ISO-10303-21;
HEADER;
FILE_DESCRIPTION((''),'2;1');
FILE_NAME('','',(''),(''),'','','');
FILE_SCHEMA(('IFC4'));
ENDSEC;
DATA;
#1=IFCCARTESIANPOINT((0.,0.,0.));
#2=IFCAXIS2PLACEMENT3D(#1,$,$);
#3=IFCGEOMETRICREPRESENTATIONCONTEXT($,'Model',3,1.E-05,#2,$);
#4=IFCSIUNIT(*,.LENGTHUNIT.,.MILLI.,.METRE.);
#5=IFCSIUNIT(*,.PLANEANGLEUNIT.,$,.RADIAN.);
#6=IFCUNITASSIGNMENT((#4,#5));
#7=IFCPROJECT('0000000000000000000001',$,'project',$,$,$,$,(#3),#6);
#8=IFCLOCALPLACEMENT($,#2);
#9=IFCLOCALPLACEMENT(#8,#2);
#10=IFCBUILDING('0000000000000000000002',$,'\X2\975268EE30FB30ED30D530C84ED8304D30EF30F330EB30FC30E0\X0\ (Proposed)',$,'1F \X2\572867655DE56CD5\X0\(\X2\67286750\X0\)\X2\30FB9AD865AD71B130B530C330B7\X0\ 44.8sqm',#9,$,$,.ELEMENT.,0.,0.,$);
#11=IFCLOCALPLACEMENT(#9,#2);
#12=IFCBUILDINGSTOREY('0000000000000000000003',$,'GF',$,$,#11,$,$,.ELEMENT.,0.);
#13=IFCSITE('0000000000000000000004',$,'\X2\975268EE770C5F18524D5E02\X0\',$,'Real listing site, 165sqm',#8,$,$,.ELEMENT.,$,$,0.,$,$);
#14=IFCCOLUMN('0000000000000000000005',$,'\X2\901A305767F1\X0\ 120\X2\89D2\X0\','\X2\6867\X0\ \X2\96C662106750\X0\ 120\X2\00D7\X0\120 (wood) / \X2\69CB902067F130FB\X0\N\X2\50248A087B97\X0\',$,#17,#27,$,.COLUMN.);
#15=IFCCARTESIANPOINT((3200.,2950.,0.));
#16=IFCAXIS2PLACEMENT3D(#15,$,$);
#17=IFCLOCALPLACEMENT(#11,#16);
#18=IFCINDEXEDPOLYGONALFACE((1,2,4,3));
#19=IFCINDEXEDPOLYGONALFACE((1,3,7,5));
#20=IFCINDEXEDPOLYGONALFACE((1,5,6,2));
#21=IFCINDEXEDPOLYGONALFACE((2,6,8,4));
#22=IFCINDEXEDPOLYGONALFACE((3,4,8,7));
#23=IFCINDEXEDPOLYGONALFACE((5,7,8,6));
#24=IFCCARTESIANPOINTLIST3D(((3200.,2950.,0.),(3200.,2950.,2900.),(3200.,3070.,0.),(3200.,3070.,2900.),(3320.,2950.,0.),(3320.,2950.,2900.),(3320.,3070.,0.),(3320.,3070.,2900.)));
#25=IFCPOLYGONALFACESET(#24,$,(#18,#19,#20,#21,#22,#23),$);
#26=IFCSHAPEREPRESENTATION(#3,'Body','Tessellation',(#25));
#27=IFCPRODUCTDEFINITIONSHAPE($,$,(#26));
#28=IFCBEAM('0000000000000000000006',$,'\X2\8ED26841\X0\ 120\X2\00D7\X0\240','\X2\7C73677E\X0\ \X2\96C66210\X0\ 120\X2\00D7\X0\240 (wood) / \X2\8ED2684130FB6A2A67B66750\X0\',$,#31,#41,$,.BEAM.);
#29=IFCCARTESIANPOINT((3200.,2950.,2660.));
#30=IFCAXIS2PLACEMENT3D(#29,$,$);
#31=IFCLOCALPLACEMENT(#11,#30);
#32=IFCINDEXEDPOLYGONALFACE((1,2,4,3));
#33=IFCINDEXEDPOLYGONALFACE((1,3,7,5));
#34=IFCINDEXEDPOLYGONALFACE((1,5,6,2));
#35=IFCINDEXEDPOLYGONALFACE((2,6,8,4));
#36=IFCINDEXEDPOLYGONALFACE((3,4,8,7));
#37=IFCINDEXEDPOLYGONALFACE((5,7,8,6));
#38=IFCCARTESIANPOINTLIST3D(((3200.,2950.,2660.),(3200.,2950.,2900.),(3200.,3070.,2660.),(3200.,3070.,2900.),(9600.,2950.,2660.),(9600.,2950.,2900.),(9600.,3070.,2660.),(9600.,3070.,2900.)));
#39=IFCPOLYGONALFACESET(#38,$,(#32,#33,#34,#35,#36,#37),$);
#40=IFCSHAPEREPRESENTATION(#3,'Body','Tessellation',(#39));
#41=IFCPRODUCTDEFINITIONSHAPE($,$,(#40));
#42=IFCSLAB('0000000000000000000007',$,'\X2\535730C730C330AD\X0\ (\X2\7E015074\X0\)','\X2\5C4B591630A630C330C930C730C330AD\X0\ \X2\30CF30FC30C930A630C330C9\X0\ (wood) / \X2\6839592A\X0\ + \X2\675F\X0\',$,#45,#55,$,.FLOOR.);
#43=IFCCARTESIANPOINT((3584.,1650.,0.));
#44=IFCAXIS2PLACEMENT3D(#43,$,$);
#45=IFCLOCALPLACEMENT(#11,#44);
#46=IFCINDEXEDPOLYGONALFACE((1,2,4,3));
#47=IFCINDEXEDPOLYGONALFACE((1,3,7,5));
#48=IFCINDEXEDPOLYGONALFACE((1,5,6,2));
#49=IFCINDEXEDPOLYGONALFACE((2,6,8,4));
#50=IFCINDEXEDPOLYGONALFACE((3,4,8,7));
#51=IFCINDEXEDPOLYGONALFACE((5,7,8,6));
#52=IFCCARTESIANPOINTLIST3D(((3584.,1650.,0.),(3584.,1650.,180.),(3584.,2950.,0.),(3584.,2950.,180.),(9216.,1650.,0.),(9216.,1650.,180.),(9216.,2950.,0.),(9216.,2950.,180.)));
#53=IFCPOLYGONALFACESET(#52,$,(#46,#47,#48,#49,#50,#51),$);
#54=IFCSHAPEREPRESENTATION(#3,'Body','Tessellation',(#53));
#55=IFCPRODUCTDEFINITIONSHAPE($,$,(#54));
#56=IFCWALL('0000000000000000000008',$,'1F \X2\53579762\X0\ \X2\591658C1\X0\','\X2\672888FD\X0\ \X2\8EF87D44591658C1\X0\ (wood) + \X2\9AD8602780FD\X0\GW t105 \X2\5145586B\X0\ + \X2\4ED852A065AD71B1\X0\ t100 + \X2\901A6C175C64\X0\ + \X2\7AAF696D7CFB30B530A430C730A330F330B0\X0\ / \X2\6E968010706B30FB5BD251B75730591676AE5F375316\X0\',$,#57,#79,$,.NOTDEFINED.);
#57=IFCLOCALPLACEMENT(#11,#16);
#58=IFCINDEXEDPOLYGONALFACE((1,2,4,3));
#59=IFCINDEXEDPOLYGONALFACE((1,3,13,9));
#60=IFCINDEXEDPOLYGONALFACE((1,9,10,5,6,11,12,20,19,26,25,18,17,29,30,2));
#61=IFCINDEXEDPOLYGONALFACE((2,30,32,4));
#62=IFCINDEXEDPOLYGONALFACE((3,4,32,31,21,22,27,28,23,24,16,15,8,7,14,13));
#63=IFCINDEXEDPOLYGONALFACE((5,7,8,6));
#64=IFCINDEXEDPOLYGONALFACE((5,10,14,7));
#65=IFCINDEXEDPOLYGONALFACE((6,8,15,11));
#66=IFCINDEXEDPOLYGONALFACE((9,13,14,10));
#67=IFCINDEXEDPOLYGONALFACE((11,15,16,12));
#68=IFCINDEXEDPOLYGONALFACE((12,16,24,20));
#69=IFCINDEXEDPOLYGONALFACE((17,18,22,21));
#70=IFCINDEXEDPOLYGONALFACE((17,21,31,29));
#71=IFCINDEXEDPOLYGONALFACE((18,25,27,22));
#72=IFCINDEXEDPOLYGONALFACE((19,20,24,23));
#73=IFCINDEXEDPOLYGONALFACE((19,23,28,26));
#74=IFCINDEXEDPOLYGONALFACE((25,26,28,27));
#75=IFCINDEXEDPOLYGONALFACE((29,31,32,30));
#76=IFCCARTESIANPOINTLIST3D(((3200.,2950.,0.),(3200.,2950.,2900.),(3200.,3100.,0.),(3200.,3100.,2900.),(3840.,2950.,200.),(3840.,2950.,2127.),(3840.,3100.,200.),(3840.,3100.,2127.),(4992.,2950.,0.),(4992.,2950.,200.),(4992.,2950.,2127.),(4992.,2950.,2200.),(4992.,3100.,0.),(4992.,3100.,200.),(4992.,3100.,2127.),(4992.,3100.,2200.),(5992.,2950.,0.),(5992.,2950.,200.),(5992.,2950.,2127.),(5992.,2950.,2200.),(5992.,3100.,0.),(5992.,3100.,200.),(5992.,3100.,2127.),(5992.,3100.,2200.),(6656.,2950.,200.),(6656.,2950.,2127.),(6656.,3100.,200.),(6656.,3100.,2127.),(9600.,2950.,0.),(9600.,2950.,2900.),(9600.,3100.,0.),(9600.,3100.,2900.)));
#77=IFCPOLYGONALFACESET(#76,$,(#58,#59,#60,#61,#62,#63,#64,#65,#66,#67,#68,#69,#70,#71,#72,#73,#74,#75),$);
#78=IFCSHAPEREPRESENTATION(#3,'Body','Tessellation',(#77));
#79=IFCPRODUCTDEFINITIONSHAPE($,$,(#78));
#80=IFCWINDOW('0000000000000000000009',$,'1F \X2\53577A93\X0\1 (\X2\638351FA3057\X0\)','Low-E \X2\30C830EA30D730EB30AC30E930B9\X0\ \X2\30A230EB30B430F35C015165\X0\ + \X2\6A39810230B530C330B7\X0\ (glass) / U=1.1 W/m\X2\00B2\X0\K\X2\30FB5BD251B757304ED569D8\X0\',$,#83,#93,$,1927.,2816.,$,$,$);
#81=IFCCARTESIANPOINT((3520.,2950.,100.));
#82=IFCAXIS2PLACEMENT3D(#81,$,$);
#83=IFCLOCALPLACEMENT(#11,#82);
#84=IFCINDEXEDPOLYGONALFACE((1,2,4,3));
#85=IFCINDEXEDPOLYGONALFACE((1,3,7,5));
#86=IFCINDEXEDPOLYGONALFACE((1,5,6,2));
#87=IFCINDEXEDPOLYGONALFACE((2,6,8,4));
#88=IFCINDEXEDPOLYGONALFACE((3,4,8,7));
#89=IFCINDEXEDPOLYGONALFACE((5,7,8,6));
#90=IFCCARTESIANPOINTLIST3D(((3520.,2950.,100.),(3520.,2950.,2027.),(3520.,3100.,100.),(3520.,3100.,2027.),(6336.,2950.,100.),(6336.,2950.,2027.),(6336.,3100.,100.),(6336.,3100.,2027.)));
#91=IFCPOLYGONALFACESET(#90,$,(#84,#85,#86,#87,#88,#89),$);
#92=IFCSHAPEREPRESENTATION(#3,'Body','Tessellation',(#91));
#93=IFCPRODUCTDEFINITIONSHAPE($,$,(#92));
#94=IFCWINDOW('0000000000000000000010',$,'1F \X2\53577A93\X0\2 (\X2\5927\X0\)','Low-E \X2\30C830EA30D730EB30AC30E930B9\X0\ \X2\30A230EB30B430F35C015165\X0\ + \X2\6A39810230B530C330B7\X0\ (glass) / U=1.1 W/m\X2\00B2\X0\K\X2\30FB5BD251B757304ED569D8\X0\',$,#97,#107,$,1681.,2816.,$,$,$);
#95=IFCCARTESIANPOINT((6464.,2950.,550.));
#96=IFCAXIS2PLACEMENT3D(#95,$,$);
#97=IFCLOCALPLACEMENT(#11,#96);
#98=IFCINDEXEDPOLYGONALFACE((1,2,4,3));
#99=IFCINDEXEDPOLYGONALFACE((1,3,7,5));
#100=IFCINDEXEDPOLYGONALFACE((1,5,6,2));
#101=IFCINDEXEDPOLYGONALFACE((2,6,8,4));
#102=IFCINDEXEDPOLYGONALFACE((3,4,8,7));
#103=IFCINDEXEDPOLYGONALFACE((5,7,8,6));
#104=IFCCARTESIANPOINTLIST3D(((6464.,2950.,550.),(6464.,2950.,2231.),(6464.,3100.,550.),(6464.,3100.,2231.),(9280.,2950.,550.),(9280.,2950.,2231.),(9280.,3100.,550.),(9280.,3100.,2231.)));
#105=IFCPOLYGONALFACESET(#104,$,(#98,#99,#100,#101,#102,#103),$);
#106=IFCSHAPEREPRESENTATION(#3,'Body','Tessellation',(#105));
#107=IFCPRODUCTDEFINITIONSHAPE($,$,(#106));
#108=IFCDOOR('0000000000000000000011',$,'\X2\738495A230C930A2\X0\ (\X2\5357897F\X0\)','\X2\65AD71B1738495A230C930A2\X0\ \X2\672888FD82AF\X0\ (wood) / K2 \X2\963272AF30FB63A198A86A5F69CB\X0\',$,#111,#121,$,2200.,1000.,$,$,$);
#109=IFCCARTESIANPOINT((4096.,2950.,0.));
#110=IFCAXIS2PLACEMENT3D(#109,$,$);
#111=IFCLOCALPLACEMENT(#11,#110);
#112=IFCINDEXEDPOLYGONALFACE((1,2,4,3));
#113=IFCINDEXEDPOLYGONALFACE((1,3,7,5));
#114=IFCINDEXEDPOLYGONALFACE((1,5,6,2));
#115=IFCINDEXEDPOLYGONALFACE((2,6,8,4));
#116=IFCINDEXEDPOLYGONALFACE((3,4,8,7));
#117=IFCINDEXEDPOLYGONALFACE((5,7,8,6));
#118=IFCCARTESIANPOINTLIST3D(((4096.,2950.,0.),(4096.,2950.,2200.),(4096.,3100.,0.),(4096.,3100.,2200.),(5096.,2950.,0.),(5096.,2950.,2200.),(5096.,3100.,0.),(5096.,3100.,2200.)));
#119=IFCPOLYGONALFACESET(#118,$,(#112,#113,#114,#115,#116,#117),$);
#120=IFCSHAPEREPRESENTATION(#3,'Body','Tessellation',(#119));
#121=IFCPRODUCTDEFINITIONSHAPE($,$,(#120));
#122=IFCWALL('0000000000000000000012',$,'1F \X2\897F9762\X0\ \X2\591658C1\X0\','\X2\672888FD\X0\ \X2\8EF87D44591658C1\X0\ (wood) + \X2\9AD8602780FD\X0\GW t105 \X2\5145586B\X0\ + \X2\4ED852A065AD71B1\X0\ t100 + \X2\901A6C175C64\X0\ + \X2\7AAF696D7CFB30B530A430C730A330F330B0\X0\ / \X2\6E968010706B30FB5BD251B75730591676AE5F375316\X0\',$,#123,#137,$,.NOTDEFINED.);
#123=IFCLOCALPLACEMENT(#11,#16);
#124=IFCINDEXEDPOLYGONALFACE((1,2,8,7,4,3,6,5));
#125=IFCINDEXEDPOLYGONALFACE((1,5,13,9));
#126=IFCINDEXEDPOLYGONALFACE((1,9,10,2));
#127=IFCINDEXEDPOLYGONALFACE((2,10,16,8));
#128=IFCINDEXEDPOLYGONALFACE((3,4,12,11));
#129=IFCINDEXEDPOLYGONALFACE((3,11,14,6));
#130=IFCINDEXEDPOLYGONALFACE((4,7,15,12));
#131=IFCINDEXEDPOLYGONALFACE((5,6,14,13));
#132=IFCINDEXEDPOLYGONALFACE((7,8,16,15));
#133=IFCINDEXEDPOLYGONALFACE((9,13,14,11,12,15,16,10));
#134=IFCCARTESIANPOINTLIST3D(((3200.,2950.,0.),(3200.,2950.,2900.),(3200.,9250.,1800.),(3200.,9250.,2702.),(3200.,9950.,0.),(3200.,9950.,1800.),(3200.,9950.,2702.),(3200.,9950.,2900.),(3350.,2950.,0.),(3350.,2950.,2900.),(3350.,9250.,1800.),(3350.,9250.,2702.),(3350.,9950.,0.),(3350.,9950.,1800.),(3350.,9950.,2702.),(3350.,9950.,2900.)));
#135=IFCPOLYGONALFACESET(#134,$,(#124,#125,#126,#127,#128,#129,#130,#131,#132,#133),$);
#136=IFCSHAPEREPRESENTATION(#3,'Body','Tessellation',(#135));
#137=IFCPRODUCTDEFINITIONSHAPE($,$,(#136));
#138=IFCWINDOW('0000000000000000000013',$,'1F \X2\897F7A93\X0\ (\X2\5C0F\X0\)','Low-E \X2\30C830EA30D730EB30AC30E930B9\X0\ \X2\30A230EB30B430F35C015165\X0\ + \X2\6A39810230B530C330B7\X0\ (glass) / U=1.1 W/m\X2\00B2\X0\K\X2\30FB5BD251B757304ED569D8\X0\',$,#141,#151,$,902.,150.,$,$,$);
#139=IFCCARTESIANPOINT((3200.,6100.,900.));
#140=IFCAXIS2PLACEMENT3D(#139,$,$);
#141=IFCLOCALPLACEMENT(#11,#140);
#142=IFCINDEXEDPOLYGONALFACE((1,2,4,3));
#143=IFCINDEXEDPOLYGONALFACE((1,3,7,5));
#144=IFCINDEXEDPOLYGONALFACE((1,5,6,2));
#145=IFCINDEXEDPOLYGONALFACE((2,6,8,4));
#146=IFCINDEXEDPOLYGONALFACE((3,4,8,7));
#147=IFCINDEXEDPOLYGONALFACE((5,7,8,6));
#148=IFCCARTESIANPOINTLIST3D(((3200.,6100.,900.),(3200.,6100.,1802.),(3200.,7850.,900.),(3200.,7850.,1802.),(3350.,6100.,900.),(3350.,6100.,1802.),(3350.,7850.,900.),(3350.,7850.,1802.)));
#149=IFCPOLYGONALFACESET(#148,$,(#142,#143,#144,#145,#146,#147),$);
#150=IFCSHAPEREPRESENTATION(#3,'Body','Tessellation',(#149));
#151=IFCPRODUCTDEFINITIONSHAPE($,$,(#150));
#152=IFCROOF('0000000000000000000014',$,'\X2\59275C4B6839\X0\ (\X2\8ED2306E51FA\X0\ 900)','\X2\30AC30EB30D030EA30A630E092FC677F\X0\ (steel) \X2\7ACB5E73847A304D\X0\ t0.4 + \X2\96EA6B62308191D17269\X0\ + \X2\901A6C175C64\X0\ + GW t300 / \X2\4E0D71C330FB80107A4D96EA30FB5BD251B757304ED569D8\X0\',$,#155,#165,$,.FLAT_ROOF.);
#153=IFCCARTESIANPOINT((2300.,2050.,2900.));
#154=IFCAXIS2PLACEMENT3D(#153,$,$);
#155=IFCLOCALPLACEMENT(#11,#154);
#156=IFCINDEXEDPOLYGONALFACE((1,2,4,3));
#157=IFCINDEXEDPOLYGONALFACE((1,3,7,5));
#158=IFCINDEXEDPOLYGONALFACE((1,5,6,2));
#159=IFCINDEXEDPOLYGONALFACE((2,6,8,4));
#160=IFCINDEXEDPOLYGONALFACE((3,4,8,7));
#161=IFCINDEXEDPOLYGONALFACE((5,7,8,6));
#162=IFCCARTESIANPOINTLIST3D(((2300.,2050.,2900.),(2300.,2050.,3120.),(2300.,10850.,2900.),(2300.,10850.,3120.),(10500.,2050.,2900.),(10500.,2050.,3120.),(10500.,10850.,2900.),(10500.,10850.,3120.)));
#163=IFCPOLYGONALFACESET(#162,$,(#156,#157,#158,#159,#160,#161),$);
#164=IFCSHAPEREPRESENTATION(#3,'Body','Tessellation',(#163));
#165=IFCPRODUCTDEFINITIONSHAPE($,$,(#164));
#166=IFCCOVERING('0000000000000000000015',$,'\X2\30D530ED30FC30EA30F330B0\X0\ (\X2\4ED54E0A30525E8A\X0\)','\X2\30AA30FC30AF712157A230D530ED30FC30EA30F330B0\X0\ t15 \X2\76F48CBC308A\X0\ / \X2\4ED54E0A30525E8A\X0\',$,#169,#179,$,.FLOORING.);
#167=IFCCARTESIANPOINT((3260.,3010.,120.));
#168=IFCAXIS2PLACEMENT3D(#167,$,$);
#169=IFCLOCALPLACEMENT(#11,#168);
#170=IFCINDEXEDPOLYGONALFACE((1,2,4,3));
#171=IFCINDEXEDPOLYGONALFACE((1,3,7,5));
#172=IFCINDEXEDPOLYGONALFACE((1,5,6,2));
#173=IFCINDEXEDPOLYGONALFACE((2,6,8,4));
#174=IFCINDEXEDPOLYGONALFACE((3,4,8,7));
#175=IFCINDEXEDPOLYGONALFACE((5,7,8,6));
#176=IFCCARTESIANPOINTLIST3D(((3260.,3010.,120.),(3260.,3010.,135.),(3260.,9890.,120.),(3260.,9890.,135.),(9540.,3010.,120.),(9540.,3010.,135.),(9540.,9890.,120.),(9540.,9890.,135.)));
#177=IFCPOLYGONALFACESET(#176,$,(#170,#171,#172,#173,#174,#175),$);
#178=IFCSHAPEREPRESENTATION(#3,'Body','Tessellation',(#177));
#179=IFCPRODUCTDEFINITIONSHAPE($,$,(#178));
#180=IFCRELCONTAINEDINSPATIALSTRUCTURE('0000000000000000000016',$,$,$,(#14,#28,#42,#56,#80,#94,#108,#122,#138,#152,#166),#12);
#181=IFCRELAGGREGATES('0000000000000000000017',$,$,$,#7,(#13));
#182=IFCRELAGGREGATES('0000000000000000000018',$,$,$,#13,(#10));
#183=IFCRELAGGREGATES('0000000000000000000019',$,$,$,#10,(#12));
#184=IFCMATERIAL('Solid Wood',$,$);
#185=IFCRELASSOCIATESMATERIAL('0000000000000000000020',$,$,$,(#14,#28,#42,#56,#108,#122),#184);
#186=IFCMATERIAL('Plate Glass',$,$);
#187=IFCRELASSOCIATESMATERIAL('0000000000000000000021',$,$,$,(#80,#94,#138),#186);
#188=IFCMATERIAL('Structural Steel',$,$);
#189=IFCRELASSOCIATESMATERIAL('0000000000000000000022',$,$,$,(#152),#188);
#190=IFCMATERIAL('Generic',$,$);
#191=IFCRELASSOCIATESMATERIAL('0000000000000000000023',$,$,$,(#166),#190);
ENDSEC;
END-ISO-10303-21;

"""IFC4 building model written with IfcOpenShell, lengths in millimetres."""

from ifc_helpers import new_model, si_unit, frame, frame_2d, origin, place, context, project, spatial, rectangle, extrude, material, element, fill, save


model = new_model("IFC4")

# Units and contexts
model_context = context("Model", 3, precision=1e-05, world=origin())
ifc_project = project(units=[si_unit("LENGTHUNIT", "METRE", prefix="MILLI"), si_unit("PLANEANGLEUNIT", "RADIAN")], contexts=[model_context])

# Site, building, storey
site_placement = place(None, origin())
site = spatial("IfcSite", under=ifc_project, at=site_placement, Name="青森県弘前市", ObjectType="Real listing site, 165sqm", CompositionType="ELEMENT", RefElevation=0.0)
building_placement = place(site_placement, origin())
building = spatial("IfcBuilding", under=site, at=building_placement, Name="青森・ロフト付きワンルーム (Proposed)", ObjectType="1F 在来工法(木材)・高断熱サッシ 44.8sqm", CompositionType="ELEMENT", ElevationOfRefHeight=0.0, ElevationOfTerrain=0.0)
storey_placement = place(building_placement, origin())
storey = spatial("IfcBuildingStorey", under=building, at=storey_placement, Name="GF", CompositionType="ELEMENT", Elevation=0.0)

# Column
ifc_material_1 = material(Name="Solid Wood")
column_1_placement = place(storey_placement, frame((3200.0, 2950.0, 0.0)))
element("IfcColumn", 1, at=column_1_placement, inside=storey, material=ifc_material_1, Name="通し柱 120角", Description="桧 集成材 120×120 (wood) / 構造柱・N値計算", PredefinedType="COLUMN", context=model_context, shape_type="SweptSolid", body=[
    extrude(rectangle(XDim=120.0, YDim=120.0, at=frame_2d((60.0, 60.0))), frame((3200.0, 2950.0, 0.0)), (0.0, 0.0, 1.0), 2900.0),
])

# Beam
beam_1_placement = place(storey_placement, frame((3200.0, 2950.0, 2660.0)))
element("IfcBeam", 2, at=beam_1_placement, inside=storey, material=ifc_material_1, Name="軒桁 120×240", Description="米松 集成 120×240 (wood) / 軒桁・横架材", PredefinedType="BEAM", context=model_context, shape_type="SweptSolid", body=[
    extrude(rectangle(XDim=6400.0, YDim=120.0, at=frame_2d((3200.0, 60.0))), frame((3200.0, 2950.0, 2660.0)), (0.0, 0.0, 1.0), 240.0),
])

# Slab
slab_1_placement = place(storey_placement, frame((3584.0, 1650.0, 0.0)))
element("IfcSlab", 3, at=slab_1_placement, inside=storey, material=ifc_material_1, Name="南デッキ (縁側)", Description="屋外ウッドデッキ ハードウッド (wood) / 根太 + 束", PredefinedType="FLOOR", context=model_context, shape_type="SweptSolid", body=[
    extrude(rectangle(XDim=5632.0, YDim=1300.0, at=frame_2d((2816.0, 650.0))), frame((3584.0, 1650.0, 0.0)), (0.0, 0.0, 1.0), 180.0),
])

# Wall, openings, windows, door
wall_1_placement = place(storey_placement, frame((3200.0, 2950.0, 0.0)))
wall_1 = element("IfcWall", 4, at=wall_1_placement, inside=storey, material=ifc_material_1, Name="1F 南面 外壁", Description="木製 軸組外壁 (wood) + 高性能GW t105 充填 + 付加断熱 t100 + 通気層 + 窯業系サイディング / 準耐火・寒冷地外皮強化", PredefinedType="NOTDEFINED", context=model_context, shape_type="SweptSolid", body=[
    extrude(rectangle(XDim=6400.0, YDim=150.0, at=frame_2d((3200.0, 75.0))), frame((3200.0, 2950.0, 0.0)), (0.0, 0.0, 1.0), 2900.0),
])
opening_1_placement = place(storey_placement, frame((3520.0, 2950.0, 100.0)))
opening_1 = element("IfcOpeningElement", 5, at=opening_1_placement, cuts=wall_1, PredefinedType="NOTDEFINED", context=model_context, shape_type="SweptSolid", body=[
    extrude(rectangle(XDim=2816.0, YDim=150.0, at=frame_2d((1408.0, 75.0))), frame((3520.0, 2950.0, 100.0)), (0.0, 0.0, 1.0), 1927.0),
])
opening_2_placement = place(storey_placement, frame((6464.0, 2950.0, 550.0)))
opening_2 = element("IfcOpeningElement", 6, at=opening_2_placement, cuts=wall_1, PredefinedType="NOTDEFINED", context=model_context, shape_type="SweptSolid", body=[
    extrude(rectangle(XDim=2816.0, YDim=150.0, at=frame_2d((1408.0, 75.0))), frame((6464.0, 2950.0, 550.0)), (0.0, 0.0, 1.0), 1681.0),
])
opening_3_placement = place(storey_placement, frame((4096.0, 2950.0, 0.0)))
opening_3 = element("IfcOpeningElement", 7, at=opening_3_placement, cuts=wall_1, PredefinedType="NOTDEFINED", context=model_context, shape_type="SweptSolid", body=[
    extrude(rectangle(XDim=1000.0, YDim=150.0, at=frame_2d((500.0, 75.0))), frame((4096.0, 2950.0, 0.0)), (0.0, 0.0, 1.0), 2200.0),
])
ifc_material_2 = material(Name="Plate Glass")
window_1_placement = place(storey_placement, frame((3520.0, 2950.0, 100.0)))
window_1 = element("IfcWindow", 8, at=window_1_placement, inside=storey, material=ifc_material_2, Name="1F 南窓1 (掃出し)", Description="Low-E トリプルガラス アルゴン封入 + 樹脂サッシ (glass) / U=1.1 W/m²K・寒冷地仕様", OverallHeight=1927.0, OverallWidth=2816.0, context=model_context, shape_type="SweptSolid", body=[
    extrude(rectangle(XDim=2816.0, YDim=150.0, at=frame_2d((1408.0, 75.0))), frame((3520.0, 2950.0, 100.0)), (0.0, 0.0, 1.0), 1927.0),
])
fill(opening_1, window_1)
window_2_placement = place(storey_placement, frame((6464.0, 2950.0, 550.0)))
window_2 = element("IfcWindow", 9, at=window_2_placement, inside=storey, material=ifc_material_2, Name="1F 南窓2 (大)", Description="Low-E トリプルガラス アルゴン封入 + 樹脂サッシ (glass) / U=1.1 W/m²K・寒冷地仕様", OverallHeight=1681.0, OverallWidth=2816.0, context=model_context, shape_type="SweptSolid", body=[
    extrude(rectangle(XDim=2816.0, YDim=150.0, at=frame_2d((1408.0, 75.0))), frame((6464.0, 2950.0, 550.0)), (0.0, 0.0, 1.0), 1681.0),
])
fill(opening_2, window_2)
door_placement = place(storey_placement, frame((4096.0, 2950.0, 0.0)))
door = element("IfcDoor", 10, at=door_placement, inside=storey, material=ifc_material_1, Name="玄関ドア (南西)", Description="断熱玄関ドア 木製芯 (wood) / K2 防犯・採風機構", OverallHeight=2200.0, OverallWidth=1000.0, context=model_context, shape_type="SweptSolid", body=[
    extrude(rectangle(XDim=1000.0, YDim=150.0, at=frame_2d((500.0, 75.0))), frame((4096.0, 2950.0, 0.0)), (0.0, 0.0, 1.0), 2200.0),
])
fill(opening_3, door)

# Wall, opening, window
wall_2_placement = place(storey_placement, frame((3200.0, 2950.0, 0.0)))
wall_2 = element("IfcWall", 11, at=wall_2_placement, inside=storey, material=ifc_material_1, Name="1F 西面 外壁", Description="木製 軸組外壁 (wood) + 高性能GW t105 充填 + 付加断熱 t100 + 通気層 + 窯業系サイディング / 準耐火・寒冷地外皮強化", PredefinedType="NOTDEFINED", context=model_context, shape_type="SweptSolid", body=[
    extrude(rectangle(XDim=150.0, YDim=7000.0, at=frame_2d((75.0, 3500.0))), frame((3200.0, 2950.0, 0.0)), (0.0, 0.0, 1.0), 2900.0),
])
opening_4_placement = place(storey_placement, frame((3200.0, 6100.0, 900.0)))
opening_4 = element("IfcOpeningElement", 12, at=opening_4_placement, cuts=wall_2, PredefinedType="NOTDEFINED", context=model_context, shape_type="SweptSolid", body=[
    extrude(rectangle(XDim=150.0, YDim=1750.0, at=frame_2d((75.0, 875.0))), frame((3200.0, 6100.0, 900.0)), (0.0, 0.0, 1.0), 902.0),
])
window_3_placement = place(storey_placement, frame((3200.0, 6100.0, 900.0)))
window_3 = element("IfcWindow", 13, at=window_3_placement, inside=storey, material=ifc_material_2, Name="1F 西窓 (小)", Description="Low-E トリプルガラス アルゴン封入 + 樹脂サッシ (glass) / U=1.1 W/m²K・寒冷地仕様", OverallHeight=902.0, OverallWidth=150.0, context=model_context, shape_type="SweptSolid", body=[
    extrude(rectangle(XDim=150.0, YDim=1750.0, at=frame_2d((75.0, 875.0))), frame((3200.0, 6100.0, 900.0)), (0.0, 0.0, 1.0), 902.0),
])
fill(opening_4, window_3)

# Roof
ifc_material_3 = material(Name="Structural Steel")
roof_placement = place(storey_placement, frame((2300.0, 2050.0, 2900.0)))
element("IfcRoof", 14, at=roof_placement, inside=storey, material=ifc_material_3, Name="大屋根 (軒の出 900)", Description="ガルバリウム鋼板 (steel) 立平葺き t0.4 + 雪止め金物 + 通気層 + GW t300 / 不燃・耐積雪・寒冷地仕様", PredefinedType="FLAT_ROOF", context=model_context, shape_type="SweptSolid", body=[
    extrude(rectangle(XDim=8200.0, YDim=8800.0, at=frame_2d((4100.0, 4400.0))), frame((2300.0, 2050.0, 2900.0)), (0.0, 0.0, 1.0), 220.0),
])

# Covering
ifc_material_4 = material(Name="Generic")
covering_1_placement = place(storey_placement, frame((3260.0, 3010.0, 120.0)))
element("IfcCovering", 15, at=covering_1_placement, inside=storey, material=ifc_material_4, Name="フローリング (仕上げ床)", Description="オーク無垢フローリング t15 直貼り / 仕上げ床", PredefinedType="FLOORING", context=model_context, shape_type="SweptSolid", body=[
    extrude(rectangle(XDim=6280.0, YDim=6880.0, at=frame_2d((3140.0, 3440.0))), frame((3260.0, 3010.0, 120.0)), (0.0, 0.0, 1.0), 15.0),
])

save(model, "model.ifc")
